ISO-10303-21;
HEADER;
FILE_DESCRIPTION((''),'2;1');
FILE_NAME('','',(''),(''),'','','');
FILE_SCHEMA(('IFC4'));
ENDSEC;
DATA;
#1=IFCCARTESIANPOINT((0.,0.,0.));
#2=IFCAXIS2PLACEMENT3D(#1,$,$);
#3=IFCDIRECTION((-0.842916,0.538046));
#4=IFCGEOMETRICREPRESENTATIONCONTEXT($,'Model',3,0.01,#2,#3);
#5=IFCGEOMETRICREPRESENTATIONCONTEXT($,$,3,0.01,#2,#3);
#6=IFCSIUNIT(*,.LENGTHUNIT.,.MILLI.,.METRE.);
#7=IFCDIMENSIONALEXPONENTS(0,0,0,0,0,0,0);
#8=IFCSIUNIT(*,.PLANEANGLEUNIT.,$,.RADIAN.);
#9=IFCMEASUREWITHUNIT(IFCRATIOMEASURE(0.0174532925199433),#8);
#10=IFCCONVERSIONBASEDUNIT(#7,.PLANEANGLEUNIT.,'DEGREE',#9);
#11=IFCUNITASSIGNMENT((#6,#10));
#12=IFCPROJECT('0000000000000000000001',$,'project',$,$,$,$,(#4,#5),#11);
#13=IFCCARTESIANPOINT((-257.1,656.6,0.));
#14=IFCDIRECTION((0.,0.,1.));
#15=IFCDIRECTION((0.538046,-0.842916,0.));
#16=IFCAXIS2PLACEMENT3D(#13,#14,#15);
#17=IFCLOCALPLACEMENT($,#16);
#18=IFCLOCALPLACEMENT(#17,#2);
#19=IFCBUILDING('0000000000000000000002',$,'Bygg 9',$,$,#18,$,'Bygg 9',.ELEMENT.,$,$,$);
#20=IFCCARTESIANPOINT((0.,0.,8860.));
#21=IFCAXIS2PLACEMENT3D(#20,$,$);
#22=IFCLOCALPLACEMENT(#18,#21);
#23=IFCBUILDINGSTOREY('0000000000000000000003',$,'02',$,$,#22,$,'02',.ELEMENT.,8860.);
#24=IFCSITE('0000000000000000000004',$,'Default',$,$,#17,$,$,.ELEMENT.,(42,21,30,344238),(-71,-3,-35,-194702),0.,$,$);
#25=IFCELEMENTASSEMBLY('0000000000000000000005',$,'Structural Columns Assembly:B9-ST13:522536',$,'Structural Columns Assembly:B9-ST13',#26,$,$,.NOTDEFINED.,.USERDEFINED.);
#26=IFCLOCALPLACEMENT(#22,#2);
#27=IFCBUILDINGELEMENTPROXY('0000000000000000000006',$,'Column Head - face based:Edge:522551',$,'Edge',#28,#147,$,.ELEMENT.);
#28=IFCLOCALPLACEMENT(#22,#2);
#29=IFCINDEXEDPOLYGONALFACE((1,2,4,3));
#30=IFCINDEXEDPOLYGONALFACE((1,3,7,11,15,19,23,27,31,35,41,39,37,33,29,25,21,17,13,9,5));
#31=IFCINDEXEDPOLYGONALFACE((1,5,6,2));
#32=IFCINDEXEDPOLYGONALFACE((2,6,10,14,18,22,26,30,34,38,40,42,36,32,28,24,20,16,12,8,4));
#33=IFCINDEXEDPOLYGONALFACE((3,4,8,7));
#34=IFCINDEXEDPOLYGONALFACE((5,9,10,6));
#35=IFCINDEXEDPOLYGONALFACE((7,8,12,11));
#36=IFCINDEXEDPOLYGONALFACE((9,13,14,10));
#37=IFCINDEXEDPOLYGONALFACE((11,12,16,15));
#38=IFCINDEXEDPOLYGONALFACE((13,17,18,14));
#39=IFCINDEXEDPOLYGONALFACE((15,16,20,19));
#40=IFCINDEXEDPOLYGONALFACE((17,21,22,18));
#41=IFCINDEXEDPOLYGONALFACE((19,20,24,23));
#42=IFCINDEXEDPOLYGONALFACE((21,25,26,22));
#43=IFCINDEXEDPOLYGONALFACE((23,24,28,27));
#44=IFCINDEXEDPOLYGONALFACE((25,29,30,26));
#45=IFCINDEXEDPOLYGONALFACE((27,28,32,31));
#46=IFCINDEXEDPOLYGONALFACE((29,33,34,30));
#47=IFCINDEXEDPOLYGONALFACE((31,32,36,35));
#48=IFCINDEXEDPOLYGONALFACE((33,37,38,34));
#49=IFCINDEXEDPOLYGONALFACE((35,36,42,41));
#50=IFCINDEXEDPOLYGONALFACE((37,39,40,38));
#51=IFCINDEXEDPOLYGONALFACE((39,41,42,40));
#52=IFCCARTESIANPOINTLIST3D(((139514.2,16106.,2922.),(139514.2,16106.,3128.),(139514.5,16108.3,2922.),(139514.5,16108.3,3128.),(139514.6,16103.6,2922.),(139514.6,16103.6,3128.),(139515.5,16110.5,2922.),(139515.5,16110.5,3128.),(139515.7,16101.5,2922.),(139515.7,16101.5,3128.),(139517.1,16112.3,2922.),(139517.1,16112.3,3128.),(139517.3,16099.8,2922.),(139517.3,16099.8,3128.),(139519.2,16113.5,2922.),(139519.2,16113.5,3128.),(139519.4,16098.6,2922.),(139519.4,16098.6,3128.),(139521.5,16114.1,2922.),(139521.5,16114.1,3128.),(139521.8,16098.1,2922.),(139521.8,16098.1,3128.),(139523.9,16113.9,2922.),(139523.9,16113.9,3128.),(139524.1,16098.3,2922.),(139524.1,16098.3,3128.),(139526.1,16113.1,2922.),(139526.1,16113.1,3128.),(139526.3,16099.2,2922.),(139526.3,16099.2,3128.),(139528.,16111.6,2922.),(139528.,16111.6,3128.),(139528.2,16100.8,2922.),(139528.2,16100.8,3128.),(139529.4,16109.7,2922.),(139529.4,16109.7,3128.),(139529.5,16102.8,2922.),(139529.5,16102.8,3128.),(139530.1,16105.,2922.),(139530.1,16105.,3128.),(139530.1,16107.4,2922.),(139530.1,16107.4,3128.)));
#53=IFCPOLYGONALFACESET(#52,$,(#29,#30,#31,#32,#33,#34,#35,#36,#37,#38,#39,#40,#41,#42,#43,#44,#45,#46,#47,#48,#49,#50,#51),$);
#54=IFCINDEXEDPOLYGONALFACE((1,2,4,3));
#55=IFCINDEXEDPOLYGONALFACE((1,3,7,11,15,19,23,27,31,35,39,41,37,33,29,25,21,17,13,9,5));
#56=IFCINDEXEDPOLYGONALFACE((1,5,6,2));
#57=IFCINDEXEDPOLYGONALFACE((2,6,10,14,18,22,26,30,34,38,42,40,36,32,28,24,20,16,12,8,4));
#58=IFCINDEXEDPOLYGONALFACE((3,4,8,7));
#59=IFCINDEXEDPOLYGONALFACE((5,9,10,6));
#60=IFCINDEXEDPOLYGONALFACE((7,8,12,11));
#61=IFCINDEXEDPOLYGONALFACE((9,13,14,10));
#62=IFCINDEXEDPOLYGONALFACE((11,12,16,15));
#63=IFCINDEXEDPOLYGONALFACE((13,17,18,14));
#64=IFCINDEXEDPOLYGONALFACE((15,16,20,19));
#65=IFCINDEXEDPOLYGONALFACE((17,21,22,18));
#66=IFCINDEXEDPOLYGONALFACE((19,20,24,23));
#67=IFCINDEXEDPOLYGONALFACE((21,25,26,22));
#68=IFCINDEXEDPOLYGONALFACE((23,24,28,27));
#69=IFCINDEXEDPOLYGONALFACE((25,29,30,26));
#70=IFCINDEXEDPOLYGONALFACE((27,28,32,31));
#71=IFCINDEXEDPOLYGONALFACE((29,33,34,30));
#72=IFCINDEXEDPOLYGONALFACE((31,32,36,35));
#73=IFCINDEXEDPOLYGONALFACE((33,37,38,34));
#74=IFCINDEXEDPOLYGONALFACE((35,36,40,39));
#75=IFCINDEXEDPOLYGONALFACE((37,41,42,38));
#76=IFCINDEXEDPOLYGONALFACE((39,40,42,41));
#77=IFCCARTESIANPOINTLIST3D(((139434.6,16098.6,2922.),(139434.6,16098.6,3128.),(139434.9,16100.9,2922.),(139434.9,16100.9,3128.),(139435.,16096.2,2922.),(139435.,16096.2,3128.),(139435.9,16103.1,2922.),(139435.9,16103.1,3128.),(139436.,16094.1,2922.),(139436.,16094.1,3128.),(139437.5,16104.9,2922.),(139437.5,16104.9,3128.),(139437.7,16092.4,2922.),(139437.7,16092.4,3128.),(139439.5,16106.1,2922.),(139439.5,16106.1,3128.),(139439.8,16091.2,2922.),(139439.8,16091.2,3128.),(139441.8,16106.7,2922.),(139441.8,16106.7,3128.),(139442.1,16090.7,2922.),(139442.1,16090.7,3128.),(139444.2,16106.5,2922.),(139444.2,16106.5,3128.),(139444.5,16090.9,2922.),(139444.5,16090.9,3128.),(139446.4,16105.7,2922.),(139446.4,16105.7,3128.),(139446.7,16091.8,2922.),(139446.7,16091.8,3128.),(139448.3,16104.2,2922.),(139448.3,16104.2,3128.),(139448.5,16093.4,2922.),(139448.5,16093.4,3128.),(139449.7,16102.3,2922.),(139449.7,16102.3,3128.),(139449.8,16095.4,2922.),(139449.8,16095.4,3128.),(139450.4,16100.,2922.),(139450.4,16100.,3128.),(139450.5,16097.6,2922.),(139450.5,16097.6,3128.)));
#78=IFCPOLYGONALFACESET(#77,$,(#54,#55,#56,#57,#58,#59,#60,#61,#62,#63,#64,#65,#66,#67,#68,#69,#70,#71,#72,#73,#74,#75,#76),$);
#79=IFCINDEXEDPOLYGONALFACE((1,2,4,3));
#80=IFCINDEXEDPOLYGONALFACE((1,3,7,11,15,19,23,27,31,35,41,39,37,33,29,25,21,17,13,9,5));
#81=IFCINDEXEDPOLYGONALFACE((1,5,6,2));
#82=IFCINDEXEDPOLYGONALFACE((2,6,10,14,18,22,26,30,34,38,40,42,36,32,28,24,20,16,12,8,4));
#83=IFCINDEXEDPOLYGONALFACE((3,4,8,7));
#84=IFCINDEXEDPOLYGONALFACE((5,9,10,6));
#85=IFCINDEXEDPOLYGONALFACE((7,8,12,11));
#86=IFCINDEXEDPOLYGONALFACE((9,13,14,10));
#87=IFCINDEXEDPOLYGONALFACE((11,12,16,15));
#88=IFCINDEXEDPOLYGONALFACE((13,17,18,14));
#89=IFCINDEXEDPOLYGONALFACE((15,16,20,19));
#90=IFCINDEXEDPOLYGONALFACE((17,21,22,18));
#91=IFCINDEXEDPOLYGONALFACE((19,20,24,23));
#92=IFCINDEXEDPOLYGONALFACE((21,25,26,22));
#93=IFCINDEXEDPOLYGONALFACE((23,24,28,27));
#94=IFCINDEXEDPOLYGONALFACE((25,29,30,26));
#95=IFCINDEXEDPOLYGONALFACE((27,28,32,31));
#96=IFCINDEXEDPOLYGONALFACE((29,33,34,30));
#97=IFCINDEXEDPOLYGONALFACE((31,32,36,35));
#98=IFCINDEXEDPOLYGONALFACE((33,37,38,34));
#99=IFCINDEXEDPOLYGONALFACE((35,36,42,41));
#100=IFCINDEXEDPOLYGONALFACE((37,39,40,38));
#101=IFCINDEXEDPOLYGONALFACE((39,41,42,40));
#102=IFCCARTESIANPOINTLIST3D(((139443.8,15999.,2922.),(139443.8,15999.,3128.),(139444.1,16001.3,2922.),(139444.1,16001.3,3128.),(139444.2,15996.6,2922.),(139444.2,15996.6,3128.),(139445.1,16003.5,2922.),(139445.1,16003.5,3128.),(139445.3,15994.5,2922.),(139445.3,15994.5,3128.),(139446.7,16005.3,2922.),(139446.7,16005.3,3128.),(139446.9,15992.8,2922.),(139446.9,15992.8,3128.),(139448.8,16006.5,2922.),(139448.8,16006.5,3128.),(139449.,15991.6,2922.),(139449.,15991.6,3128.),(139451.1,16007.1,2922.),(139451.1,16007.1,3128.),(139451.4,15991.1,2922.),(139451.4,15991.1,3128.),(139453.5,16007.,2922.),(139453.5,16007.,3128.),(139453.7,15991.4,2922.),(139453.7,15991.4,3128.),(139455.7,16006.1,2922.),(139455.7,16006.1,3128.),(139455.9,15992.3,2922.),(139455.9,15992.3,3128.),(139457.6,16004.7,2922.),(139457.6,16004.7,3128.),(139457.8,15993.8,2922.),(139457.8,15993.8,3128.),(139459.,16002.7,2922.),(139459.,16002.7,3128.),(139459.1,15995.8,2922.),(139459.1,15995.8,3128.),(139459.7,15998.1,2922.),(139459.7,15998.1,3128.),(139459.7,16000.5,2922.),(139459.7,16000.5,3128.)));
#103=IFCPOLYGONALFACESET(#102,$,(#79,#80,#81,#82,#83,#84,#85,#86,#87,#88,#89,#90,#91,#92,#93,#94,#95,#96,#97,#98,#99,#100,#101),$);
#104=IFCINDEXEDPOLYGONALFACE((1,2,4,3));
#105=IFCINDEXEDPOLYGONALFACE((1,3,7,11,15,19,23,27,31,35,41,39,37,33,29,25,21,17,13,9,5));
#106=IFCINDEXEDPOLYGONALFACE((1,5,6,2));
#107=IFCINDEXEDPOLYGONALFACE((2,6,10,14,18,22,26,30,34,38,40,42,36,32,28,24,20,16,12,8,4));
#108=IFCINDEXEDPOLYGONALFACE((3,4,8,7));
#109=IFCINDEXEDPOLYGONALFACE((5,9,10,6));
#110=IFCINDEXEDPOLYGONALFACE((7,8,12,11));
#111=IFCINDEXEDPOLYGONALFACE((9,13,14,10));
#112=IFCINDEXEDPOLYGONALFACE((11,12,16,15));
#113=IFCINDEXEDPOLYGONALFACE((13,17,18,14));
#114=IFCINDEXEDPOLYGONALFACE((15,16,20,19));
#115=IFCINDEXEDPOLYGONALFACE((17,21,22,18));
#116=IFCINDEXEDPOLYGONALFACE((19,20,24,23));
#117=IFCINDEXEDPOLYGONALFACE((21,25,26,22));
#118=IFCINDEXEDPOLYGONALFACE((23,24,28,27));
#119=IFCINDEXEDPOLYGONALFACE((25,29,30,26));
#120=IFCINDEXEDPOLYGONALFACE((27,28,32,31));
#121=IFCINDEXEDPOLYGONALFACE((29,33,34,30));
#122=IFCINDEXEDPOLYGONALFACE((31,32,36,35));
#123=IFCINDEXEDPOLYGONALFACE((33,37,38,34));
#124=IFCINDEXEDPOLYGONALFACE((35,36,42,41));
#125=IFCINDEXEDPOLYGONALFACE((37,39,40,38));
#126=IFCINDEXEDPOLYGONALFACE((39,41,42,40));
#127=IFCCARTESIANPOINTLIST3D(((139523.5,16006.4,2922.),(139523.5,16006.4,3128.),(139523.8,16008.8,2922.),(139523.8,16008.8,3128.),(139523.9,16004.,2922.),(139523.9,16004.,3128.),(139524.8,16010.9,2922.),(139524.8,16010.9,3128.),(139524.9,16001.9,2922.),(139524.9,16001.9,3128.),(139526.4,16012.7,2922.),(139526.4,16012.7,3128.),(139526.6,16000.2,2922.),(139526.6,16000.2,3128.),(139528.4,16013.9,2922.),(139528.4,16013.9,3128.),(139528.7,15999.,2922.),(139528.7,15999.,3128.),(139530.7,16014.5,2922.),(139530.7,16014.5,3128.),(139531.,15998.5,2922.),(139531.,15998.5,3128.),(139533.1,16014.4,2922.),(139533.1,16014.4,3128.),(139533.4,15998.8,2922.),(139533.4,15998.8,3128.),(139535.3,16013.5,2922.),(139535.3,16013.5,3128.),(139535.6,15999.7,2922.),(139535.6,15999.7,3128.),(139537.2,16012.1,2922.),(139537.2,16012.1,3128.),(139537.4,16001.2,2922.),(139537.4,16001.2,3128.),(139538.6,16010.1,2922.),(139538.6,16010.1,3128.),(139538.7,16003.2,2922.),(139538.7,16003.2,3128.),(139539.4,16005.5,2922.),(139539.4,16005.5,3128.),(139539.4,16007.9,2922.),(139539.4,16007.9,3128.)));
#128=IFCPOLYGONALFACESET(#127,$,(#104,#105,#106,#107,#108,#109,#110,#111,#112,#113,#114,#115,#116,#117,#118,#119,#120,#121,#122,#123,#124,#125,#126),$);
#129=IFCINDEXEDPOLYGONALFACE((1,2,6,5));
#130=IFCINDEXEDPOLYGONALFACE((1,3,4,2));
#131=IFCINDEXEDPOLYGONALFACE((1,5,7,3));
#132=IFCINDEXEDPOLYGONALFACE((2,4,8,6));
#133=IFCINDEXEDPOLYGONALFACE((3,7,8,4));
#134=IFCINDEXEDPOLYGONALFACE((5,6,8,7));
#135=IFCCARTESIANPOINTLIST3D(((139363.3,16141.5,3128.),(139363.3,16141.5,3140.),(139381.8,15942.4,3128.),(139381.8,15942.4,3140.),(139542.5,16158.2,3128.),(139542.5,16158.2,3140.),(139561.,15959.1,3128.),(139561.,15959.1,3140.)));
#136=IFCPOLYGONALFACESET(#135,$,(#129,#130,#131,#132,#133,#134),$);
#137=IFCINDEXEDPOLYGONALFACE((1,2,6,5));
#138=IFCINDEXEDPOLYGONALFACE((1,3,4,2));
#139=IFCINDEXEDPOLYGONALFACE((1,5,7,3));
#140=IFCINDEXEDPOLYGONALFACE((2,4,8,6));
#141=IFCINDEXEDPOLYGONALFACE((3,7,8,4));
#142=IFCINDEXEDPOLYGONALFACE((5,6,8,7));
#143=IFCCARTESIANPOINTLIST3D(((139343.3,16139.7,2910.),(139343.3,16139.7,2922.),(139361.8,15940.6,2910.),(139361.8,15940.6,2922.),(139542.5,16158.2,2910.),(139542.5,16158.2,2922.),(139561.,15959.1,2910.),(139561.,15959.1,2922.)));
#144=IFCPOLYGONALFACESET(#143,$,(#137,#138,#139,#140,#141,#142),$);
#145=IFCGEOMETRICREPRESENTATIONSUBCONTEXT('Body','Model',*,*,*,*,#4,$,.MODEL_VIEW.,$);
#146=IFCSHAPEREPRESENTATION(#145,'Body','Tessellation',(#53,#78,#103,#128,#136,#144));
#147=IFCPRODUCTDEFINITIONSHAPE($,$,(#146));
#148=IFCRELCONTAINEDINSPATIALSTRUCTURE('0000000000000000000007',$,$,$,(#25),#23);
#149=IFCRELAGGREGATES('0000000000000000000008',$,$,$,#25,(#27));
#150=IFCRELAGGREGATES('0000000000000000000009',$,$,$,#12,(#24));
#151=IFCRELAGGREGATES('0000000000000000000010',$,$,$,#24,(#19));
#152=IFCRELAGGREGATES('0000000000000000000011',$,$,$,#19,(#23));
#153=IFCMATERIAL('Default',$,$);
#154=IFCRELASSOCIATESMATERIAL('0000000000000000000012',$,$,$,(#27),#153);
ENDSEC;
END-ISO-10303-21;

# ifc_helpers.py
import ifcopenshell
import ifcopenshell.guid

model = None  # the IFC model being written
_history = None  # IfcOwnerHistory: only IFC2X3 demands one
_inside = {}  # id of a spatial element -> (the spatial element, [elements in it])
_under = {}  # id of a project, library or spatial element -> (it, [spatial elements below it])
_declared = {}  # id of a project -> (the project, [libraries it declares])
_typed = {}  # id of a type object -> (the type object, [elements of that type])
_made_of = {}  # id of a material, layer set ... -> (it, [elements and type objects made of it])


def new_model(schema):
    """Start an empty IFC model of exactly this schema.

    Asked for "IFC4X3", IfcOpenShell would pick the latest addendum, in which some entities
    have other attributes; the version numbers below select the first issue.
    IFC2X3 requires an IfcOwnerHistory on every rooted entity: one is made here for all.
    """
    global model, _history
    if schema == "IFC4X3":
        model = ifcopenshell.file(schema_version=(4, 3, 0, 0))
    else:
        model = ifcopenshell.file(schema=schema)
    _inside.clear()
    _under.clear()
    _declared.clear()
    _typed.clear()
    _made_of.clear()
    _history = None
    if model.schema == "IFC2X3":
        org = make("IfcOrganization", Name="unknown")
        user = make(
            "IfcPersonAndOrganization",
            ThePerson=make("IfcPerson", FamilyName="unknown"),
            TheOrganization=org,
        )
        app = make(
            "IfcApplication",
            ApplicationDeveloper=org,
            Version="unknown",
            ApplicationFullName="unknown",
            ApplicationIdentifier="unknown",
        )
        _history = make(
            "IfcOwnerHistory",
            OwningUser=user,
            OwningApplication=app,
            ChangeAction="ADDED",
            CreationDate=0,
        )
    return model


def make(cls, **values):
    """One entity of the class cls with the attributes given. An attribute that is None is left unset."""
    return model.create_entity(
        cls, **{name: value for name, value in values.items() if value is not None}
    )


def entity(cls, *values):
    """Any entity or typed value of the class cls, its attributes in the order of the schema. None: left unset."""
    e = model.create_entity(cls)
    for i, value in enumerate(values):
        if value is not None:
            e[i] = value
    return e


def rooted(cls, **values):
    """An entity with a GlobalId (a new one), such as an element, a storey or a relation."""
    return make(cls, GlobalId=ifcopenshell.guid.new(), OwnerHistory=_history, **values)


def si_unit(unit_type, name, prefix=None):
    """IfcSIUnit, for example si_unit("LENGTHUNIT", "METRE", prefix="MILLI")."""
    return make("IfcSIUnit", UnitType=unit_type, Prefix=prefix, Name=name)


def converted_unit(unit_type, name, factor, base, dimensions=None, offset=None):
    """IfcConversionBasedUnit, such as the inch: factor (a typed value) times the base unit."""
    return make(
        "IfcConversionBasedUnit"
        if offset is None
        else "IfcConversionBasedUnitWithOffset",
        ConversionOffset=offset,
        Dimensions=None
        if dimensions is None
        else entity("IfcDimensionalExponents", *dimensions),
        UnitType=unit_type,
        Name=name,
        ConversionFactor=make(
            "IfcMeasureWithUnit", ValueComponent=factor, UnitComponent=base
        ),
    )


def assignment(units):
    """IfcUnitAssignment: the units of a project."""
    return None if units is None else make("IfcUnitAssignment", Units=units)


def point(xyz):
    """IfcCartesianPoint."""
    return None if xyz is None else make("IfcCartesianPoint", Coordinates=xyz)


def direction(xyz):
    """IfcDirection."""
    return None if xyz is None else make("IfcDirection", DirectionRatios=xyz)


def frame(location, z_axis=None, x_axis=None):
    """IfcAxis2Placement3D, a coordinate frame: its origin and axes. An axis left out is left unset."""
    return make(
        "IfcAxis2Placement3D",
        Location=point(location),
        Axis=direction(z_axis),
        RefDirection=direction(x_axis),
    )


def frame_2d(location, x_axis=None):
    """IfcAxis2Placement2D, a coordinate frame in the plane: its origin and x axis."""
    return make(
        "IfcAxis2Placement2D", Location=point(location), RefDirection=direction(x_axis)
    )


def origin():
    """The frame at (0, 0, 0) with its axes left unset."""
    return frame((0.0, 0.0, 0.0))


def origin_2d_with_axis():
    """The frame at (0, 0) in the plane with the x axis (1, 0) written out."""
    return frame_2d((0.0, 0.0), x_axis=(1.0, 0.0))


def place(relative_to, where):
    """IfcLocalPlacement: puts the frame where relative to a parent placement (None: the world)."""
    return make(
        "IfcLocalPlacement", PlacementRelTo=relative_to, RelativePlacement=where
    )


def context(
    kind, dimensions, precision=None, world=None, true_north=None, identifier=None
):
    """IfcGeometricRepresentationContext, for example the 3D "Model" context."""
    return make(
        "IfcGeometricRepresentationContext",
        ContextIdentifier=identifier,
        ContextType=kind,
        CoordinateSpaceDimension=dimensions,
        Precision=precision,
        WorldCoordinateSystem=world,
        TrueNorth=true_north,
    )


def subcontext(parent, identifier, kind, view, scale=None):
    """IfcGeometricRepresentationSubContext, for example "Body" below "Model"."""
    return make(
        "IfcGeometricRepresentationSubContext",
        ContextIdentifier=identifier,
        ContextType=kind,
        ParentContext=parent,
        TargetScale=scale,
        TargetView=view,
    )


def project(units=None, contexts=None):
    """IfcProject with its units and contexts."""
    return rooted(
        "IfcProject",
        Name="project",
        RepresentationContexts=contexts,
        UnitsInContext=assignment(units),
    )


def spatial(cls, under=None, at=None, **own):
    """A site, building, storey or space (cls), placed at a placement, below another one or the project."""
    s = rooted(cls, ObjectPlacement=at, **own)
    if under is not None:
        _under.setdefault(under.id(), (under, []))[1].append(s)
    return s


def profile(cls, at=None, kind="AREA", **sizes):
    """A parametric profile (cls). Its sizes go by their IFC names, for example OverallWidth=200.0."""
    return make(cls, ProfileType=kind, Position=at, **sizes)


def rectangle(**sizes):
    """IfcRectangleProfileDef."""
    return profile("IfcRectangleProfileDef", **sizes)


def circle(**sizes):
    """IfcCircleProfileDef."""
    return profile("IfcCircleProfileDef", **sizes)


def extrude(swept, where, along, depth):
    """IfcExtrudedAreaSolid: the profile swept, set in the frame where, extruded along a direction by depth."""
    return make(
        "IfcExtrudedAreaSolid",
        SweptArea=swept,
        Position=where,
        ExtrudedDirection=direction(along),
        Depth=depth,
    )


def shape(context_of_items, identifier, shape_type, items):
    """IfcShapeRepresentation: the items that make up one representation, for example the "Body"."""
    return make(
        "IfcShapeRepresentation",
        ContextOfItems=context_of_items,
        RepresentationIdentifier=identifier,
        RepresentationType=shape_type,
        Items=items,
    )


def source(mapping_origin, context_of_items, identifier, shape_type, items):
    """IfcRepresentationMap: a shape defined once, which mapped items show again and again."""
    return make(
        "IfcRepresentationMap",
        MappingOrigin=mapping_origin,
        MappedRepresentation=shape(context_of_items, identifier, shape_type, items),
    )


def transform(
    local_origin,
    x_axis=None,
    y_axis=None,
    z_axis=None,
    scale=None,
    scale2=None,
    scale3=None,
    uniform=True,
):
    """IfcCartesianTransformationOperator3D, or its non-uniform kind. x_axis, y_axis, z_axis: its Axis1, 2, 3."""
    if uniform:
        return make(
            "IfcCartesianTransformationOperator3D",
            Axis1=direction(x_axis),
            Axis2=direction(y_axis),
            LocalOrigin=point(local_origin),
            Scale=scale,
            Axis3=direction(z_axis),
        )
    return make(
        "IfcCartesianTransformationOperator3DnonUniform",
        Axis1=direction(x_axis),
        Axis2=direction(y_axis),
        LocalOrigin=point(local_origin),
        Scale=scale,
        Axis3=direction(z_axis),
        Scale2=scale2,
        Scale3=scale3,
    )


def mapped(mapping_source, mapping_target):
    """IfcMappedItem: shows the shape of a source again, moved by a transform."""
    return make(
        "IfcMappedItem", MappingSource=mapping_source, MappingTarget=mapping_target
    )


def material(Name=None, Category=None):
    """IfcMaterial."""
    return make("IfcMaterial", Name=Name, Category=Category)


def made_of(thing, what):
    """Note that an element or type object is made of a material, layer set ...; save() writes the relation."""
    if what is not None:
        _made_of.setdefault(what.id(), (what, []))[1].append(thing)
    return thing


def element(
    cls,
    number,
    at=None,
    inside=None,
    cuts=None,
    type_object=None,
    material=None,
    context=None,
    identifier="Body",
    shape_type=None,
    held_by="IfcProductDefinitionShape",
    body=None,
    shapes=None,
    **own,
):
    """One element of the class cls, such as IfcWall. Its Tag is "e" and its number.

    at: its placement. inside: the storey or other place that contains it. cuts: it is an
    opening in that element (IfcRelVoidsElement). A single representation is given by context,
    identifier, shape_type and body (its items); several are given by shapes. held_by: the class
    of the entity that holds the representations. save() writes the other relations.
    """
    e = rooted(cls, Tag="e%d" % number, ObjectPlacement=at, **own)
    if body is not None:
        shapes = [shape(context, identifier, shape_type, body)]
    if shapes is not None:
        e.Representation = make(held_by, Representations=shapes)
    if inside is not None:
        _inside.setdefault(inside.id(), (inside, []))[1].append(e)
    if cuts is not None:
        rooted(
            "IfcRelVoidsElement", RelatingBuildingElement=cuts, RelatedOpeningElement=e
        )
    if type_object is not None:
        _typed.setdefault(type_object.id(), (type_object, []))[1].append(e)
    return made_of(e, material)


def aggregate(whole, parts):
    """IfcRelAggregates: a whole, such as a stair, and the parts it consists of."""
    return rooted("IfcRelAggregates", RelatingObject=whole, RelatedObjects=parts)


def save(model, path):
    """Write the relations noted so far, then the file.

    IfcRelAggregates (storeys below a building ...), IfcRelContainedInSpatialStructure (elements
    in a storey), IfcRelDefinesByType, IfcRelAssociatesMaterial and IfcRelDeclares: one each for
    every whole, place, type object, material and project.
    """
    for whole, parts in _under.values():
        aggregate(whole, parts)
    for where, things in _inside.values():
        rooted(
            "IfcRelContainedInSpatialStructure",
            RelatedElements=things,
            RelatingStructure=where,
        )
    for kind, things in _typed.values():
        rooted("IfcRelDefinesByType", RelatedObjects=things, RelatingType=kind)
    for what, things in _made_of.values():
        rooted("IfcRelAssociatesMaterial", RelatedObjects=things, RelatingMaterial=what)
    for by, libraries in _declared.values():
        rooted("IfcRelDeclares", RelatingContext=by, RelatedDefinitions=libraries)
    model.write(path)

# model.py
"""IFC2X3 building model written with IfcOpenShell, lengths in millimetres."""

from ifc_helpers import new_model, entity, si_unit, converted_unit, direction, frame, frame_2d, origin, origin_2d_with_axis, place, context, subcontext, project, spatial, rectangle, circle, extrude, source, transform, mapped, material, element, aggregate, save


model = new_model("IFC2X3")

# Units and contexts
model_context = context("Model", 3, precision=0.01, world=origin(), true_north=direction((-0.842916, 0.538046)))
context_of_model = context(None, 3, precision=0.01, world=origin(), true_north=direction((-0.842916, 0.538046)))
body_context = subcontext(model_context, "Body", "Model", "MODEL_VIEW")
ifc_project = project(units=[si_unit("LENGTHUNIT", "METRE", prefix="MILLI"), converted_unit("PLANEANGLEUNIT", "DEGREE", entity("IfcRatioMeasure", 0.0174532925199433), si_unit("PLANEANGLEUNIT", "RADIAN"), dimensions=[0, 0, 0, 0, 0, 0, 0])], contexts=[model_context, context_of_model])

# Site, building, storey
site_placement = place(None, frame((-257.1, 656.6, 0.0), z_axis=(0.0, 0.0, 1.0), x_axis=(0.538046, -0.842916, 0.0)))
site = spatial("IfcSite", under=ifc_project, at=site_placement, Name="Default", CompositionType="ELEMENT", RefLatitude=(42, 21, 30, 344238), RefLongitude=(-71, -3, -35, -194702), RefElevation=0.0)
building_placement = place(site_placement, origin())
building = spatial("IfcBuilding", under=site, at=building_placement, Name="Bygg 9", LongName="Bygg 9", CompositionType="ELEMENT")
storey_placement = place(building_placement, frame((0.0, 0.0, 8860.0)))
storey = spatial("IfcBuildingStorey", under=building, at=storey_placement, Name="02", LongName="02", CompositionType="ELEMENT", Elevation=8860.0)

# Shared definitions
ifc_material_1 = material(Name="Default")

# Element assembly, building element proxy
shared_shape_1 = source(origin(), body_context, "Body", "SweptSolid", [
    extrude(circle(Radius=8.0, at=frame_2d((0.0, 0.0), x_axis=(1.0, 0.0))), frame((50.0, -135.0, 12.0)), (0.0, 0.0, 1.0), 206.0),
    extrude(circle(Radius=8.0, at=frame_2d((0.0, 0.0), x_axis=(1.0, 0.0))), frame((50.0, -55.0, 12.0)), (0.0, 0.0, 1.0), 206.0),
    extrude(circle(Radius=8.0, at=frame_2d((0.0, 0.0), x_axis=(1.0, 0.0))), frame((-50.0, -55.0, 12.0)), (0.0, 0.0, 1.0), 206.0),
    extrude(circle(Radius=8.0, at=frame_2d((0.0, 0.0), x_axis=(1.0, 0.0))), frame((-50.0, -135.0, 12.0)), (0.0, 0.0, 1.0), 206.0),
    extrude(rectangle(XDim=200.0, YDim=180.0, at=origin_2d_with_axis()), frame((0.0, -70.0, 218.0), z_axis=(0.0, 0.0, 1.0), x_axis=(-1.0, 0.0, 0.0)), (0.0, 0.0, 1.0), 12.0),
    extrude(rectangle(XDim=200.0, YDim=200.0, at=origin_2d_with_axis()), frame((0.0, -60.0, 0.0), z_axis=(0.0, 0.0, 1.0), x_axis=(0.0, 1.0, 0.0)), (0.0, 0.0, 1.0), 12.0),
])
assembly_1_placement = place(storey_placement, origin())
assembly_1 = element("IfcElementAssembly", 1, at=assembly_1_placement, inside=storey, Name="Structural Columns Assembly:B9-ST13:522536", ObjectType="Structural Columns Assembly:B9-ST13", AssemblyPlace="NOTDEFINED", PredefinedType="USERDEFINED")
proxy_1_placement = place(assembly_1_placement, frame((139392.4, 16043.8, 2910.0), z_axis=(0.0, 0.0, 1.0), x_axis=(-0.092535, 0.995709, 0.0)))
proxy_1 = element("IfcBuildingElementProxy", 2, at=proxy_1_placement, material=ifc_material_1, Name="Column Head - face based:Edge:522551", ObjectType="Edge", CompositionType="ELEMENT", context=body_context, shape_type="MappedRepresentation", body=[
    mapped(shared_shape_1, transform((0.0, 0.0, 0.0), scale=1.0)),
])
aggregate(assembly_1, [proxy_1])

save(model, "model.ifc")
